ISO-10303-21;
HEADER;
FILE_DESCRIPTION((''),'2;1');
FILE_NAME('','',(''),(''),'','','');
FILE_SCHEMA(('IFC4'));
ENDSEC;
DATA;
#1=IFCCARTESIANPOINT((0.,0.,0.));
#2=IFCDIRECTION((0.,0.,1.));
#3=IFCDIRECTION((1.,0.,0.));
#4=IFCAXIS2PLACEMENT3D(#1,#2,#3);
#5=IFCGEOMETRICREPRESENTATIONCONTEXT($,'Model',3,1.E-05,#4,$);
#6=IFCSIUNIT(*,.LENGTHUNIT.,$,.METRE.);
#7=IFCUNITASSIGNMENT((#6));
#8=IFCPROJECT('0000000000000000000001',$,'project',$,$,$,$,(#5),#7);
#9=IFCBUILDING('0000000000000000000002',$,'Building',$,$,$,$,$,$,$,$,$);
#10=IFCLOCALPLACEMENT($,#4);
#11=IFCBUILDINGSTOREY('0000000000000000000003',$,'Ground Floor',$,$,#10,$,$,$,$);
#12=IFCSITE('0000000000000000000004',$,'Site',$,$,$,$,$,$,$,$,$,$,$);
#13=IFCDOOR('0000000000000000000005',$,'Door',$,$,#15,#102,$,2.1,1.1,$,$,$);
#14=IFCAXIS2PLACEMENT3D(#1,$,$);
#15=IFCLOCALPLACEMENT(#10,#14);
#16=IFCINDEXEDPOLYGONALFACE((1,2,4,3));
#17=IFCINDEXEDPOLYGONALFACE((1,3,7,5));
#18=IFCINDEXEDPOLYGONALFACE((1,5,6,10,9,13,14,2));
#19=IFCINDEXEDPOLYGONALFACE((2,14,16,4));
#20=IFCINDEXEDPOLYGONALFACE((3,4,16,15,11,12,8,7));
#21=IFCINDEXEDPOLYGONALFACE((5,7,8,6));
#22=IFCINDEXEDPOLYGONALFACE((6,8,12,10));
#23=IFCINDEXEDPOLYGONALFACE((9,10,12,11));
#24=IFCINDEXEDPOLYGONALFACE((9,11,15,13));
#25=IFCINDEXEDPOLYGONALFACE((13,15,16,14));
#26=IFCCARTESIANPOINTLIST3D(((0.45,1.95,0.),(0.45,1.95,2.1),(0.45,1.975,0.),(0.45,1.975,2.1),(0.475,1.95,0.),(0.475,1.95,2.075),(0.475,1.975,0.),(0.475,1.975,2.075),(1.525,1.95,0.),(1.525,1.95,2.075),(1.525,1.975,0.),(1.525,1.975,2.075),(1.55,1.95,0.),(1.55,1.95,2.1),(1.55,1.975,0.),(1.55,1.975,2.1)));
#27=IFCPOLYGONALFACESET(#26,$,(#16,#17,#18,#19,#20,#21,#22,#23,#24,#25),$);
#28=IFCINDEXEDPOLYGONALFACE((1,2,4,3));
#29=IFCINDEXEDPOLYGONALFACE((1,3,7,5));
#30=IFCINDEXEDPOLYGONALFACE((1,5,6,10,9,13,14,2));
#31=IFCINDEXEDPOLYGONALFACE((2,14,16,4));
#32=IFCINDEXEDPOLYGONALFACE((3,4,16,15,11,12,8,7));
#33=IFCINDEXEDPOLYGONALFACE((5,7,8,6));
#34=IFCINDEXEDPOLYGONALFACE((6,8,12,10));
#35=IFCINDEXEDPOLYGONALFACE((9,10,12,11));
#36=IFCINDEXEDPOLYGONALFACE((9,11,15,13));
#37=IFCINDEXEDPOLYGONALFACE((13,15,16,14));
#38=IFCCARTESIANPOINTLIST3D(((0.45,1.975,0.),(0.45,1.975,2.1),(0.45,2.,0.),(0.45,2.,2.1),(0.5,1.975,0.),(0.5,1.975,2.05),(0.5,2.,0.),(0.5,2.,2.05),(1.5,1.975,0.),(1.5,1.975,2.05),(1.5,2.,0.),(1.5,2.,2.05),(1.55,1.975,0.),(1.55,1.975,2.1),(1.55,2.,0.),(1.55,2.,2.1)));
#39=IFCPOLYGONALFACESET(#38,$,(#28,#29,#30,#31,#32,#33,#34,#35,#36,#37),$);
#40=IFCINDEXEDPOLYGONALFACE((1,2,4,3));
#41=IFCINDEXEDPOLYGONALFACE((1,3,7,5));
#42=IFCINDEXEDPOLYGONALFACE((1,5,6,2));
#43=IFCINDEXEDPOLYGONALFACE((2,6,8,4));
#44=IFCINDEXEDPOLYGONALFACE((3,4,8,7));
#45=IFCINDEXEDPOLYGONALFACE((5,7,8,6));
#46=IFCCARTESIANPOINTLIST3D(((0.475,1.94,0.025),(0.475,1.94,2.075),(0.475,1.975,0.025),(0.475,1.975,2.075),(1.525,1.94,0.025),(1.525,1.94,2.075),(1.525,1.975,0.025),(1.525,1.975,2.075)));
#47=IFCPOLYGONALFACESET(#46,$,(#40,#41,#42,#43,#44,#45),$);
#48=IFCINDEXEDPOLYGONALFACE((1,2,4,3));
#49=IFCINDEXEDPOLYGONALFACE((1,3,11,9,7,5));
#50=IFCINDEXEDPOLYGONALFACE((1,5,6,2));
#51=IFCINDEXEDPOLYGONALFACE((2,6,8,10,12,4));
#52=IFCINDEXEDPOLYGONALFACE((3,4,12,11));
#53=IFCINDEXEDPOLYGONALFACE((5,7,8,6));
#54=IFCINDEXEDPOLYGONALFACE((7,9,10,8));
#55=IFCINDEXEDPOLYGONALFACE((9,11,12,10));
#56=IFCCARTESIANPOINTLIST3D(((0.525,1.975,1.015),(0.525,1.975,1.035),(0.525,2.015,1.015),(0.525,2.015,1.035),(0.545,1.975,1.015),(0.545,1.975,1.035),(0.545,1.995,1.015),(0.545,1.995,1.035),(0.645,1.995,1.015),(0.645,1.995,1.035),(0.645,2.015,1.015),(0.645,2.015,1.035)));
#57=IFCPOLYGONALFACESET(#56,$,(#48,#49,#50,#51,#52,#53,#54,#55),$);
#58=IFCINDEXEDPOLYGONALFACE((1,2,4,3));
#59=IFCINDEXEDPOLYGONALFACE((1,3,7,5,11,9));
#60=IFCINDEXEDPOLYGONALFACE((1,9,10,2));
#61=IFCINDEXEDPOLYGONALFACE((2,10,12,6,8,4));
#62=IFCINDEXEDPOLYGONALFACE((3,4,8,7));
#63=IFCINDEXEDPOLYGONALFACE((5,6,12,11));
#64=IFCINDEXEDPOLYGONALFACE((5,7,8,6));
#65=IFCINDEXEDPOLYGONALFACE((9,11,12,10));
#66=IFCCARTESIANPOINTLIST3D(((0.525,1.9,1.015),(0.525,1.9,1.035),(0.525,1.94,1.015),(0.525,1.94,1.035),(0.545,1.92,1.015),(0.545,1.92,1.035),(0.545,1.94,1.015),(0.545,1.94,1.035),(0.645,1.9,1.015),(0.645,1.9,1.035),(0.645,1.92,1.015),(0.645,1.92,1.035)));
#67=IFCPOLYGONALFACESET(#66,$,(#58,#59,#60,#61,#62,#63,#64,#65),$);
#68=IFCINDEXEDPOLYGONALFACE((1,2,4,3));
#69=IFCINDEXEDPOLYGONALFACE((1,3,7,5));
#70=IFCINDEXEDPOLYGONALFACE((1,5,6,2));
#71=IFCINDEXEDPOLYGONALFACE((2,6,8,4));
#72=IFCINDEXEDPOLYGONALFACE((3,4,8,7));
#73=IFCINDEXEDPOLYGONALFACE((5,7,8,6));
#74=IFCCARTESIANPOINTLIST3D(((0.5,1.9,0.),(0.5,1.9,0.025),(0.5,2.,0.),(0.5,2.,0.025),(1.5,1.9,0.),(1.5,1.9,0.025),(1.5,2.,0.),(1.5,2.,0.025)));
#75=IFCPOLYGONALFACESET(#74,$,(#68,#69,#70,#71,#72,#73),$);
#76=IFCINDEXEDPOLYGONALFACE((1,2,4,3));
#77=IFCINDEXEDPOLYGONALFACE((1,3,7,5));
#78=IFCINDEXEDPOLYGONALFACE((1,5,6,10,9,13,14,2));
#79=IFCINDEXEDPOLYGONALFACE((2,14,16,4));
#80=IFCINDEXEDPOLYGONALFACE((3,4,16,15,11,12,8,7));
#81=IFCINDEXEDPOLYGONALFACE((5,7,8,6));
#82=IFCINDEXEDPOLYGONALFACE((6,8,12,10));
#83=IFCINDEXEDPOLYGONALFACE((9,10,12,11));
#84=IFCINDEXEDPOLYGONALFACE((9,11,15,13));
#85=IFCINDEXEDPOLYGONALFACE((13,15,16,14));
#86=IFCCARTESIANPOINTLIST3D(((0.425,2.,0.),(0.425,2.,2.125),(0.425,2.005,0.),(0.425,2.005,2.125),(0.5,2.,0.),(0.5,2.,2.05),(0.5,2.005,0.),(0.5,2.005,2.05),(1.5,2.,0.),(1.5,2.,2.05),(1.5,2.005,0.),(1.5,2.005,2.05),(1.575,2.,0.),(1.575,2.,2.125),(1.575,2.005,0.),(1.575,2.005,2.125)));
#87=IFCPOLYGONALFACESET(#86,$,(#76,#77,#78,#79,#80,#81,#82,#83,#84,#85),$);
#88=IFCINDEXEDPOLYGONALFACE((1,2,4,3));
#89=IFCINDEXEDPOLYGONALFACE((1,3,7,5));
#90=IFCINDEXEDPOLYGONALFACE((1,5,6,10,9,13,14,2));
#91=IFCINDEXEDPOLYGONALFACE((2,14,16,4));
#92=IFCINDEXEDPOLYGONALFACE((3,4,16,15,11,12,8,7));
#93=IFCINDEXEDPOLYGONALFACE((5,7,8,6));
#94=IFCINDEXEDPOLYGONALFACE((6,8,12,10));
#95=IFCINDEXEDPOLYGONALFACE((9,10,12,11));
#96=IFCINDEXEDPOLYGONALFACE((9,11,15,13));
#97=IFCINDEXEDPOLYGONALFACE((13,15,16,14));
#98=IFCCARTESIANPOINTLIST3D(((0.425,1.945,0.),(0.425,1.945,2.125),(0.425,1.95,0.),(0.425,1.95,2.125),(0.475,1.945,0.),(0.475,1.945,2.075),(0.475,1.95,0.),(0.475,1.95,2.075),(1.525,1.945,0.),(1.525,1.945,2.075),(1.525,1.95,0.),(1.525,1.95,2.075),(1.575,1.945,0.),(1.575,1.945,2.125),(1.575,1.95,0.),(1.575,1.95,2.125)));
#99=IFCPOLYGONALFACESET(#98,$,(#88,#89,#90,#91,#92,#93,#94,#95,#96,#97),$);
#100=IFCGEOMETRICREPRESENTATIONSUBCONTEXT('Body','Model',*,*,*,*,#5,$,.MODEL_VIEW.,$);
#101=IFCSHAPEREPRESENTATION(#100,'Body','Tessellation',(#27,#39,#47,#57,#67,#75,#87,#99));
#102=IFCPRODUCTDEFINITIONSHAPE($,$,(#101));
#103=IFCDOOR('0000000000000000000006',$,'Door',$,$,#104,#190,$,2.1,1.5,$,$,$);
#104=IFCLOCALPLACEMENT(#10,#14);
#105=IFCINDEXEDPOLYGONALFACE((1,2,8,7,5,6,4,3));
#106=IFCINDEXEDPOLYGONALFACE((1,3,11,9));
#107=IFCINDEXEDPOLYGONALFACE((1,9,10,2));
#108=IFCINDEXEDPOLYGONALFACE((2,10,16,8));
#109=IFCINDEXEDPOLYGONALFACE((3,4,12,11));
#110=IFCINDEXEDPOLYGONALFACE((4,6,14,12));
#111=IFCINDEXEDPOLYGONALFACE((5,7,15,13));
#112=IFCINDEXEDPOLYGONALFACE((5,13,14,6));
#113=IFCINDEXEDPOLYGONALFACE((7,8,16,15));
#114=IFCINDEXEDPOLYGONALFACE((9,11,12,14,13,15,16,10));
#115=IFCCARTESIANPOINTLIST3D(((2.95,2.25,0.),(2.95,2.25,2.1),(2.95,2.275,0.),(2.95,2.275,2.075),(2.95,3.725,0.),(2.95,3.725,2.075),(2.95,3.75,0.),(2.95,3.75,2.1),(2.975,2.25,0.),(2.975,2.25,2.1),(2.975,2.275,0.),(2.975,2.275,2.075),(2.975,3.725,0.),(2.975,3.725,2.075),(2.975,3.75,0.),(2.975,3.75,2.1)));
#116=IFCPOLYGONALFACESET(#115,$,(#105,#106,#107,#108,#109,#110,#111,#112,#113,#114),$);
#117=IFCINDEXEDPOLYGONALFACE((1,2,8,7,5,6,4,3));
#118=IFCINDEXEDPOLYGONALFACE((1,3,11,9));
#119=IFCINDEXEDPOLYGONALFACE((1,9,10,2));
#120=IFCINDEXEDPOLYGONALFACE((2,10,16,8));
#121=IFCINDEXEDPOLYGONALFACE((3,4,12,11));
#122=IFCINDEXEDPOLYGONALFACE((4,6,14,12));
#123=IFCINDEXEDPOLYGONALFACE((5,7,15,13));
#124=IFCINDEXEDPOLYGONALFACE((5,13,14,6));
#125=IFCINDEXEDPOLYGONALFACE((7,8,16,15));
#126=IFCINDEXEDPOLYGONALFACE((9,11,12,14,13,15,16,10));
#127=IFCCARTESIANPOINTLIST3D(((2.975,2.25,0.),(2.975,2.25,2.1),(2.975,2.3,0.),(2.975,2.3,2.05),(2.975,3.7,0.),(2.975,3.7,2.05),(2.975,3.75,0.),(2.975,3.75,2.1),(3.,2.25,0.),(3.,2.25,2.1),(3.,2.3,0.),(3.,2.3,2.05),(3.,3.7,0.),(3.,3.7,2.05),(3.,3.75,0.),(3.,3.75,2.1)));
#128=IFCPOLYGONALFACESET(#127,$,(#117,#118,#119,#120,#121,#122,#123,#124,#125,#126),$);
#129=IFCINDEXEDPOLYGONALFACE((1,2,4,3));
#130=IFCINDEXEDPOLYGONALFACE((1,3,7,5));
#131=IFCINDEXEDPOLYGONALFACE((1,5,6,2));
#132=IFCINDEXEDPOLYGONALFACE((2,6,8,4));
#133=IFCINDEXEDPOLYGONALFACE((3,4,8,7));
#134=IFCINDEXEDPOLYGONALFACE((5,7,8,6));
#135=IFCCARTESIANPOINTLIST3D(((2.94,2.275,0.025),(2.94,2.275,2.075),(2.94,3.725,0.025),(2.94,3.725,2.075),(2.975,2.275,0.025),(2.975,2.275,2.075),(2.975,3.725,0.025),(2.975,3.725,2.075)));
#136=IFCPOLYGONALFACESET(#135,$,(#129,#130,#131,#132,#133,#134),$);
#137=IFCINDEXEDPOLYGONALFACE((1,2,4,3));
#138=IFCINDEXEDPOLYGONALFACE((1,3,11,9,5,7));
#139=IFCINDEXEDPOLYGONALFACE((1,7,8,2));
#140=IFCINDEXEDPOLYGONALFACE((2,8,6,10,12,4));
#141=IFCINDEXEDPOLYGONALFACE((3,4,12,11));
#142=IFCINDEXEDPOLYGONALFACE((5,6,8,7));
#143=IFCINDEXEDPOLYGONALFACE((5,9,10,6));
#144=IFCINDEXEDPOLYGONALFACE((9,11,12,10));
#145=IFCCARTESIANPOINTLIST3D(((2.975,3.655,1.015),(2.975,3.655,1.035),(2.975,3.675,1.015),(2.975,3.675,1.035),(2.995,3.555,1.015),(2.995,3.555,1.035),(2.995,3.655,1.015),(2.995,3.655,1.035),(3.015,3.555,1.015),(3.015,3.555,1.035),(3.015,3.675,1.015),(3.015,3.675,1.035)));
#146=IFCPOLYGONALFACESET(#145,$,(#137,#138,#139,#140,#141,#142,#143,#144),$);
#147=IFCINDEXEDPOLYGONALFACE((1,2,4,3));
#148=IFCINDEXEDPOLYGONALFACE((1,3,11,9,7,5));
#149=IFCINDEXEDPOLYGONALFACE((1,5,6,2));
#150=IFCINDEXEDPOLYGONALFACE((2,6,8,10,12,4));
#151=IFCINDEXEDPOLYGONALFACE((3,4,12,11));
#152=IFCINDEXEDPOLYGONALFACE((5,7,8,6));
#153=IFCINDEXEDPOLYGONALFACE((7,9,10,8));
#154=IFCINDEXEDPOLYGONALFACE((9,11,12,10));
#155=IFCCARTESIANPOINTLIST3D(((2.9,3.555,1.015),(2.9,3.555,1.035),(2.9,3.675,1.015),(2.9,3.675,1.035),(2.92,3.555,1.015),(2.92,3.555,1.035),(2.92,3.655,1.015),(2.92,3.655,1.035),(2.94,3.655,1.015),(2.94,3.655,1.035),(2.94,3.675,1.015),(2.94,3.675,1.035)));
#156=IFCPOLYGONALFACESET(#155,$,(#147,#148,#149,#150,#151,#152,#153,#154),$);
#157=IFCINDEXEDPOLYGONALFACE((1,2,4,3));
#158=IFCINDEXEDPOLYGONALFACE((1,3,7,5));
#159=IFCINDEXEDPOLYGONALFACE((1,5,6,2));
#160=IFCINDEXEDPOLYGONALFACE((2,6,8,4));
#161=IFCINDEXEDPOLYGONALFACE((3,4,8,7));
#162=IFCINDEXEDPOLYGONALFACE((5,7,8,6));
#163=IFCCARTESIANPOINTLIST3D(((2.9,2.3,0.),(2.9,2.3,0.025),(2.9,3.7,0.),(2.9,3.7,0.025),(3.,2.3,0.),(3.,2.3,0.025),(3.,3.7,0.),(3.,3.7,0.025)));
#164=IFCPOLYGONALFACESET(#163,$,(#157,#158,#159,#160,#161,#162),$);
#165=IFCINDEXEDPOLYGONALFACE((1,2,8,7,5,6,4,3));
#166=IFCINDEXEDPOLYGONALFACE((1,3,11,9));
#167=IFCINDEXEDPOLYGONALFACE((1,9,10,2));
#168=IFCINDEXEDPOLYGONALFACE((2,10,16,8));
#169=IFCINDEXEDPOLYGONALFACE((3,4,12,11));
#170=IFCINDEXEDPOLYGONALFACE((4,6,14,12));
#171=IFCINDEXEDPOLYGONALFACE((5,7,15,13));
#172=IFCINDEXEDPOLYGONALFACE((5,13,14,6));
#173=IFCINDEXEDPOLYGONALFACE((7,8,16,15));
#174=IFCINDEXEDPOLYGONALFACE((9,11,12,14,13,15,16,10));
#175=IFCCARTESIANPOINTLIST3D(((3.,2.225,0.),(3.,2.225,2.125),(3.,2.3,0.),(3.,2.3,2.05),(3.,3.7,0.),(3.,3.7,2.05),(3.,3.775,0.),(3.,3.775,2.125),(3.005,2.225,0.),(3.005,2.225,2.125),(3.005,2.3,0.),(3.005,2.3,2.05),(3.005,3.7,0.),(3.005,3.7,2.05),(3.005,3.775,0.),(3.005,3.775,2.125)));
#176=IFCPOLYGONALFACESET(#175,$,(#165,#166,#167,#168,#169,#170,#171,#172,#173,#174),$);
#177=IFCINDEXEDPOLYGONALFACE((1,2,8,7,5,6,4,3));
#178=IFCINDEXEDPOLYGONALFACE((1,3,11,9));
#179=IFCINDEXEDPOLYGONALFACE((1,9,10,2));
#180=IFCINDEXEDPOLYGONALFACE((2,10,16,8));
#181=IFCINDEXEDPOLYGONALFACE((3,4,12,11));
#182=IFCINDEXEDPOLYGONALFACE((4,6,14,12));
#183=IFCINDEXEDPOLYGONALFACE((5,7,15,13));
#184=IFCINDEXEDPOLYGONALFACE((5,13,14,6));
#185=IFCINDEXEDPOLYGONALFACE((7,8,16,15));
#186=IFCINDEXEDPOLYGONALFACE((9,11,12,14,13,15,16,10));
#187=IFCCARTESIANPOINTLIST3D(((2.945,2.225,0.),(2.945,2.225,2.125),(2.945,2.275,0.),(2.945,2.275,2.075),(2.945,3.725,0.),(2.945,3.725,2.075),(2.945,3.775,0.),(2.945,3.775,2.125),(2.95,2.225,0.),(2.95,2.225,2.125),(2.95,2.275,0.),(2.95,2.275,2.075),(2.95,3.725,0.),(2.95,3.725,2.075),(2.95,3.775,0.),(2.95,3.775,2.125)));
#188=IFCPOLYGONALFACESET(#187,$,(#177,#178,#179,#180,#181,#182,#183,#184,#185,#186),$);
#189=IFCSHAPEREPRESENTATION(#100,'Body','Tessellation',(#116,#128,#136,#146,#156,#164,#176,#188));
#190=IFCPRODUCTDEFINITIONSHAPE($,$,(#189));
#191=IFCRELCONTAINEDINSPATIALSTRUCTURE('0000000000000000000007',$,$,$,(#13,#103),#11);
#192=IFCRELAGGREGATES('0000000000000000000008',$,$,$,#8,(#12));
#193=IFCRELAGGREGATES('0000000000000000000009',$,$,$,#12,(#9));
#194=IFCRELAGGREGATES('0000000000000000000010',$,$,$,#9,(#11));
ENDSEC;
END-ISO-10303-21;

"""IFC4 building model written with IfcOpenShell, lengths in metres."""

from ifc_helpers import new_model, si_unit, frame, origin_with_axes, place, context, subcontext, project, spatial, line, indexed_curve, outline, extrude, element, save


model = new_model("IFC4")

# Units and contexts
model_context = context("Model", 3, precision=1e-05, world=origin_with_axes())
body_context = subcontext(model_context, "Body", "Model", "MODEL_VIEW")
ifc_project = project(units=[si_unit("LENGTHUNIT", "METRE")], contexts=[model_context])

# Site, building, storey
site = spatial("IfcSite", under=ifc_project, Name="Site")
building = spatial("IfcBuilding", under=site, Name="Building")
storey_placement = place(None, origin_with_axes())
storey = spatial("IfcBuildingStorey", under=building, at=storey_placement, Name="Ground Floor")

# Doors
door_1_placement = place(storey_placement, frame((1.55, 2.0, 0.0), z_axis=(0.0, 0.0, 1.0), x_axis=(-1.0, 0.0, 0.0)))
element("IfcDoor", 1, at=door_1_placement, inside=storey, Name="Door", OverallHeight=2.1, OverallWidth=1.1, context=body_context, shape_type="SweptSolid", body=[
    extrude(outline(indexed_curve([(0.0, 0.0), (0.0, 2.1), (1.1, 2.1), (1.1, 0.0), (1.075, 0.0), (1.075, 2.075), (0.025, 2.075), (0.025, 0.0)], segments=[line(1, 2, 3, 4, 5, 6, 7, 8, 1)])), frame((0.0, 0.025, 0.0), z_axis=(0.0, -1.0, 0.0), x_axis=(1.0, 0.0, 0.0)), (0.0, 0.0, -1.0), 0.025),
    extrude(outline(indexed_curve([(0.0, 0.0), (0.0, 2.1), (1.1, 2.1), (1.1, 0.0), (1.05, 0.0), (1.05, 2.05), (0.05, 2.05), (0.05, 0.0)], segments=[line(1, 2, 3, 4, 5, 6, 7, 8, 1)])), frame((0.0, 0.0, 0.0), z_axis=(0.0, -1.0, 0.0), x_axis=(1.0, 0.0, 0.0)), (0.0, 0.0, -1.0), 0.025),
    extrude(outline(indexed_curve([(0.0, 0.0), (1.05, 0.0), (1.05, 0.035), (0.0, 0.035)], segments=[line(1, 2, 3, 4, 1)])), frame((0.025, 0.025, 0.025), z_axis=(0.0, 0.0, 1.0), x_axis=(1.0, 0.0, 0.0)), (0.0, 0.0, 1.0), 2.05),
    extrude(outline(indexed_curve([(0.0, 0.0), (0.0, -0.04), (-0.12, -0.04), (-0.12, -0.02), (-0.02, -0.02), (-0.02, 0.0)], segments=[line(1, 2, 3, 4, 5, 6, 1)])), frame((1.025, 0.025, 1.015), z_axis=(0.0, 0.0, 1.0), x_axis=(1.0, 0.0, 0.0)), (0.0, 0.0, 1.0), 0.02),
    extrude(outline(indexed_curve([(0.0, 0.0), (0.0, 0.04), (-0.12, 0.04), (-0.12, 0.02), (-0.02, 0.02), (-0.02, 0.0)], segments=[line(1, 2, 3, 4, 5, 6, 1)])), frame((1.025, 0.06, 1.015), z_axis=(0.0, 0.0, 1.0), x_axis=(1.0, 0.0, 0.0)), (0.0, 0.0, 1.0), 0.02),
    extrude(outline(indexed_curve([(0.0, 0.0), (1.0, 0.0), (1.0, 0.1), (0.0, 0.1)], segments=[line(1, 2, 3, 4, 1)])), frame((0.05, 0.0, 0.0), z_axis=(0.0, 0.0, 1.0), x_axis=(1.0, 0.0, 0.0)), (0.0, 0.0, 1.0), 0.025),
    extrude(outline(indexed_curve([(0.0, 0.0), (0.0, 2.125), (1.15, 2.125), (1.15, 0.0), (1.075, 0.0), (1.075, 2.05), (0.075, 2.05), (0.075, 0.0)], segments=[line(1, 2, 3, 4, 5, 6, 7, 8, 1)])), frame((-0.025, -0.005, 0.0), z_axis=(0.0, -1.0, 0.0), x_axis=(1.0, 0.0, 0.0)), (0.0, 0.0, -1.0), 0.005),
    extrude(outline(indexed_curve([(0.0, 0.0), (0.0, 2.125), (1.15, 2.125), (1.15, 0.0), (1.1, 0.0), (1.1, 2.075), (0.05, 2.075), (0.05, 0.0)], segments=[line(1, 2, 3, 4, 5, 6, 7, 8, 1)])), frame((-0.025, 0.05, 0.0), z_axis=(0.0, -1.0, 0.0), x_axis=(1.0, 0.0, 0.0)), (0.0, 0.0, -1.0), 0.005),
])
door_2_placement = place(storey_placement, frame((3.0, 2.25, 0.0), z_axis=(0.0, 0.0, 1.0), x_axis=(0.0, 1.0, 0.0)))
element("IfcDoor", 2, at=door_2_placement, inside=storey, Name="Door", OverallHeight=2.1, OverallWidth=1.5, context=body_context, shape_type="SweptSolid", body=[
    extrude(outline(indexed_curve([(0.0, 0.0), (0.0, 2.1), (1.5, 2.1), (1.5, 0.0), (1.475, 0.0), (1.475, 2.075), (0.025, 2.075), (0.025, 0.0)], segments=[line(1, 2, 3, 4, 5, 6, 7, 8, 1)])), frame((0.0, 0.025, 0.0), z_axis=(0.0, -1.0, 0.0), x_axis=(1.0, 0.0, 0.0)), (0.0, 0.0, -1.0), 0.025),
    extrude(outline(indexed_curve([(0.0, 0.0), (0.0, 2.1), (1.5, 2.1), (1.5, 0.0), (1.45, 0.0), (1.45, 2.05), (0.05, 2.05), (0.05, 0.0)], segments=[line(1, 2, 3, 4, 5, 6, 7, 8, 1)])), frame((0.0, 0.0, 0.0), z_axis=(0.0, -1.0, 0.0), x_axis=(1.0, 0.0, 0.0)), (0.0, 0.0, -1.0), 0.025),
    extrude(outline(indexed_curve([(0.0, 0.0), (1.45, 0.0), (1.45, 0.035), (0.0, 0.035)], segments=[line(1, 2, 3, 4, 1)])), frame((0.025, 0.025, 0.025), z_axis=(0.0, 0.0, 1.0), x_axis=(1.0, 0.0, 0.0)), (0.0, 0.0, 1.0), 2.05),
    extrude(outline(indexed_curve([(0.0, 0.0), (0.0, -0.04), (-0.12, -0.04), (-0.12, -0.02), (-0.02, -0.02), (-0.02, 0.0)], segments=[line(1, 2, 3, 4, 5, 6, 1)])), frame((1.425, 0.025, 1.015), z_axis=(0.0, 0.0, 1.0), x_axis=(1.0, 0.0, 0.0)), (0.0, 0.0, 1.0), 0.02),
    extrude(outline(indexed_curve([(0.0, 0.0), (0.0, 0.04), (-0.12, 0.04), (-0.12, 0.02), (-0.02, 0.02), (-0.02, 0.0)], segments=[line(1, 2, 3, 4, 5, 6, 1)])), frame((1.425, 0.06, 1.015), z_axis=(0.0, 0.0, 1.0), x_axis=(1.0, 0.0, 0.0)), (0.0, 0.0, 1.0), 0.02),
    extrude(outline(indexed_curve([(0.0, 0.0), (1.4, 0.0), (1.4, 0.1), (0.0, 0.1)], segments=[line(1, 2, 3, 4, 1)])), frame((0.05, 0.0, 0.0), z_axis=(0.0, 0.0, 1.0), x_axis=(1.0, 0.0, 0.0)), (0.0, 0.0, 1.0), 0.025),
    extrude(outline(indexed_curve([(0.0, 0.0), (0.0, 2.125), (1.55, 2.125), (1.55, 0.0), (1.475, 0.0), (1.475, 2.05), (0.075, 2.05), (0.075, 0.0)], segments=[line(1, 2, 3, 4, 5, 6, 7, 8, 1)])), frame((-0.025, -0.005, 0.0), z_axis=(0.0, -1.0, 0.0), x_axis=(1.0, 0.0, 0.0)), (0.0, 0.0, -1.0), 0.005),
    extrude(outline(indexed_curve([(0.0, 0.0), (0.0, 2.125), (1.55, 2.125), (1.55, 0.0), (1.5, 0.0), (1.5, 2.075), (0.05, 2.075), (0.05, 0.0)], segments=[line(1, 2, 3, 4, 5, 6, 7, 8, 1)])), frame((-0.025, 0.05, 0.0), z_axis=(0.0, -1.0, 0.0), x_axis=(1.0, 0.0, 0.0)), (0.0, 0.0, -1.0), 0.005),
])

save(model, "model.ifc")
